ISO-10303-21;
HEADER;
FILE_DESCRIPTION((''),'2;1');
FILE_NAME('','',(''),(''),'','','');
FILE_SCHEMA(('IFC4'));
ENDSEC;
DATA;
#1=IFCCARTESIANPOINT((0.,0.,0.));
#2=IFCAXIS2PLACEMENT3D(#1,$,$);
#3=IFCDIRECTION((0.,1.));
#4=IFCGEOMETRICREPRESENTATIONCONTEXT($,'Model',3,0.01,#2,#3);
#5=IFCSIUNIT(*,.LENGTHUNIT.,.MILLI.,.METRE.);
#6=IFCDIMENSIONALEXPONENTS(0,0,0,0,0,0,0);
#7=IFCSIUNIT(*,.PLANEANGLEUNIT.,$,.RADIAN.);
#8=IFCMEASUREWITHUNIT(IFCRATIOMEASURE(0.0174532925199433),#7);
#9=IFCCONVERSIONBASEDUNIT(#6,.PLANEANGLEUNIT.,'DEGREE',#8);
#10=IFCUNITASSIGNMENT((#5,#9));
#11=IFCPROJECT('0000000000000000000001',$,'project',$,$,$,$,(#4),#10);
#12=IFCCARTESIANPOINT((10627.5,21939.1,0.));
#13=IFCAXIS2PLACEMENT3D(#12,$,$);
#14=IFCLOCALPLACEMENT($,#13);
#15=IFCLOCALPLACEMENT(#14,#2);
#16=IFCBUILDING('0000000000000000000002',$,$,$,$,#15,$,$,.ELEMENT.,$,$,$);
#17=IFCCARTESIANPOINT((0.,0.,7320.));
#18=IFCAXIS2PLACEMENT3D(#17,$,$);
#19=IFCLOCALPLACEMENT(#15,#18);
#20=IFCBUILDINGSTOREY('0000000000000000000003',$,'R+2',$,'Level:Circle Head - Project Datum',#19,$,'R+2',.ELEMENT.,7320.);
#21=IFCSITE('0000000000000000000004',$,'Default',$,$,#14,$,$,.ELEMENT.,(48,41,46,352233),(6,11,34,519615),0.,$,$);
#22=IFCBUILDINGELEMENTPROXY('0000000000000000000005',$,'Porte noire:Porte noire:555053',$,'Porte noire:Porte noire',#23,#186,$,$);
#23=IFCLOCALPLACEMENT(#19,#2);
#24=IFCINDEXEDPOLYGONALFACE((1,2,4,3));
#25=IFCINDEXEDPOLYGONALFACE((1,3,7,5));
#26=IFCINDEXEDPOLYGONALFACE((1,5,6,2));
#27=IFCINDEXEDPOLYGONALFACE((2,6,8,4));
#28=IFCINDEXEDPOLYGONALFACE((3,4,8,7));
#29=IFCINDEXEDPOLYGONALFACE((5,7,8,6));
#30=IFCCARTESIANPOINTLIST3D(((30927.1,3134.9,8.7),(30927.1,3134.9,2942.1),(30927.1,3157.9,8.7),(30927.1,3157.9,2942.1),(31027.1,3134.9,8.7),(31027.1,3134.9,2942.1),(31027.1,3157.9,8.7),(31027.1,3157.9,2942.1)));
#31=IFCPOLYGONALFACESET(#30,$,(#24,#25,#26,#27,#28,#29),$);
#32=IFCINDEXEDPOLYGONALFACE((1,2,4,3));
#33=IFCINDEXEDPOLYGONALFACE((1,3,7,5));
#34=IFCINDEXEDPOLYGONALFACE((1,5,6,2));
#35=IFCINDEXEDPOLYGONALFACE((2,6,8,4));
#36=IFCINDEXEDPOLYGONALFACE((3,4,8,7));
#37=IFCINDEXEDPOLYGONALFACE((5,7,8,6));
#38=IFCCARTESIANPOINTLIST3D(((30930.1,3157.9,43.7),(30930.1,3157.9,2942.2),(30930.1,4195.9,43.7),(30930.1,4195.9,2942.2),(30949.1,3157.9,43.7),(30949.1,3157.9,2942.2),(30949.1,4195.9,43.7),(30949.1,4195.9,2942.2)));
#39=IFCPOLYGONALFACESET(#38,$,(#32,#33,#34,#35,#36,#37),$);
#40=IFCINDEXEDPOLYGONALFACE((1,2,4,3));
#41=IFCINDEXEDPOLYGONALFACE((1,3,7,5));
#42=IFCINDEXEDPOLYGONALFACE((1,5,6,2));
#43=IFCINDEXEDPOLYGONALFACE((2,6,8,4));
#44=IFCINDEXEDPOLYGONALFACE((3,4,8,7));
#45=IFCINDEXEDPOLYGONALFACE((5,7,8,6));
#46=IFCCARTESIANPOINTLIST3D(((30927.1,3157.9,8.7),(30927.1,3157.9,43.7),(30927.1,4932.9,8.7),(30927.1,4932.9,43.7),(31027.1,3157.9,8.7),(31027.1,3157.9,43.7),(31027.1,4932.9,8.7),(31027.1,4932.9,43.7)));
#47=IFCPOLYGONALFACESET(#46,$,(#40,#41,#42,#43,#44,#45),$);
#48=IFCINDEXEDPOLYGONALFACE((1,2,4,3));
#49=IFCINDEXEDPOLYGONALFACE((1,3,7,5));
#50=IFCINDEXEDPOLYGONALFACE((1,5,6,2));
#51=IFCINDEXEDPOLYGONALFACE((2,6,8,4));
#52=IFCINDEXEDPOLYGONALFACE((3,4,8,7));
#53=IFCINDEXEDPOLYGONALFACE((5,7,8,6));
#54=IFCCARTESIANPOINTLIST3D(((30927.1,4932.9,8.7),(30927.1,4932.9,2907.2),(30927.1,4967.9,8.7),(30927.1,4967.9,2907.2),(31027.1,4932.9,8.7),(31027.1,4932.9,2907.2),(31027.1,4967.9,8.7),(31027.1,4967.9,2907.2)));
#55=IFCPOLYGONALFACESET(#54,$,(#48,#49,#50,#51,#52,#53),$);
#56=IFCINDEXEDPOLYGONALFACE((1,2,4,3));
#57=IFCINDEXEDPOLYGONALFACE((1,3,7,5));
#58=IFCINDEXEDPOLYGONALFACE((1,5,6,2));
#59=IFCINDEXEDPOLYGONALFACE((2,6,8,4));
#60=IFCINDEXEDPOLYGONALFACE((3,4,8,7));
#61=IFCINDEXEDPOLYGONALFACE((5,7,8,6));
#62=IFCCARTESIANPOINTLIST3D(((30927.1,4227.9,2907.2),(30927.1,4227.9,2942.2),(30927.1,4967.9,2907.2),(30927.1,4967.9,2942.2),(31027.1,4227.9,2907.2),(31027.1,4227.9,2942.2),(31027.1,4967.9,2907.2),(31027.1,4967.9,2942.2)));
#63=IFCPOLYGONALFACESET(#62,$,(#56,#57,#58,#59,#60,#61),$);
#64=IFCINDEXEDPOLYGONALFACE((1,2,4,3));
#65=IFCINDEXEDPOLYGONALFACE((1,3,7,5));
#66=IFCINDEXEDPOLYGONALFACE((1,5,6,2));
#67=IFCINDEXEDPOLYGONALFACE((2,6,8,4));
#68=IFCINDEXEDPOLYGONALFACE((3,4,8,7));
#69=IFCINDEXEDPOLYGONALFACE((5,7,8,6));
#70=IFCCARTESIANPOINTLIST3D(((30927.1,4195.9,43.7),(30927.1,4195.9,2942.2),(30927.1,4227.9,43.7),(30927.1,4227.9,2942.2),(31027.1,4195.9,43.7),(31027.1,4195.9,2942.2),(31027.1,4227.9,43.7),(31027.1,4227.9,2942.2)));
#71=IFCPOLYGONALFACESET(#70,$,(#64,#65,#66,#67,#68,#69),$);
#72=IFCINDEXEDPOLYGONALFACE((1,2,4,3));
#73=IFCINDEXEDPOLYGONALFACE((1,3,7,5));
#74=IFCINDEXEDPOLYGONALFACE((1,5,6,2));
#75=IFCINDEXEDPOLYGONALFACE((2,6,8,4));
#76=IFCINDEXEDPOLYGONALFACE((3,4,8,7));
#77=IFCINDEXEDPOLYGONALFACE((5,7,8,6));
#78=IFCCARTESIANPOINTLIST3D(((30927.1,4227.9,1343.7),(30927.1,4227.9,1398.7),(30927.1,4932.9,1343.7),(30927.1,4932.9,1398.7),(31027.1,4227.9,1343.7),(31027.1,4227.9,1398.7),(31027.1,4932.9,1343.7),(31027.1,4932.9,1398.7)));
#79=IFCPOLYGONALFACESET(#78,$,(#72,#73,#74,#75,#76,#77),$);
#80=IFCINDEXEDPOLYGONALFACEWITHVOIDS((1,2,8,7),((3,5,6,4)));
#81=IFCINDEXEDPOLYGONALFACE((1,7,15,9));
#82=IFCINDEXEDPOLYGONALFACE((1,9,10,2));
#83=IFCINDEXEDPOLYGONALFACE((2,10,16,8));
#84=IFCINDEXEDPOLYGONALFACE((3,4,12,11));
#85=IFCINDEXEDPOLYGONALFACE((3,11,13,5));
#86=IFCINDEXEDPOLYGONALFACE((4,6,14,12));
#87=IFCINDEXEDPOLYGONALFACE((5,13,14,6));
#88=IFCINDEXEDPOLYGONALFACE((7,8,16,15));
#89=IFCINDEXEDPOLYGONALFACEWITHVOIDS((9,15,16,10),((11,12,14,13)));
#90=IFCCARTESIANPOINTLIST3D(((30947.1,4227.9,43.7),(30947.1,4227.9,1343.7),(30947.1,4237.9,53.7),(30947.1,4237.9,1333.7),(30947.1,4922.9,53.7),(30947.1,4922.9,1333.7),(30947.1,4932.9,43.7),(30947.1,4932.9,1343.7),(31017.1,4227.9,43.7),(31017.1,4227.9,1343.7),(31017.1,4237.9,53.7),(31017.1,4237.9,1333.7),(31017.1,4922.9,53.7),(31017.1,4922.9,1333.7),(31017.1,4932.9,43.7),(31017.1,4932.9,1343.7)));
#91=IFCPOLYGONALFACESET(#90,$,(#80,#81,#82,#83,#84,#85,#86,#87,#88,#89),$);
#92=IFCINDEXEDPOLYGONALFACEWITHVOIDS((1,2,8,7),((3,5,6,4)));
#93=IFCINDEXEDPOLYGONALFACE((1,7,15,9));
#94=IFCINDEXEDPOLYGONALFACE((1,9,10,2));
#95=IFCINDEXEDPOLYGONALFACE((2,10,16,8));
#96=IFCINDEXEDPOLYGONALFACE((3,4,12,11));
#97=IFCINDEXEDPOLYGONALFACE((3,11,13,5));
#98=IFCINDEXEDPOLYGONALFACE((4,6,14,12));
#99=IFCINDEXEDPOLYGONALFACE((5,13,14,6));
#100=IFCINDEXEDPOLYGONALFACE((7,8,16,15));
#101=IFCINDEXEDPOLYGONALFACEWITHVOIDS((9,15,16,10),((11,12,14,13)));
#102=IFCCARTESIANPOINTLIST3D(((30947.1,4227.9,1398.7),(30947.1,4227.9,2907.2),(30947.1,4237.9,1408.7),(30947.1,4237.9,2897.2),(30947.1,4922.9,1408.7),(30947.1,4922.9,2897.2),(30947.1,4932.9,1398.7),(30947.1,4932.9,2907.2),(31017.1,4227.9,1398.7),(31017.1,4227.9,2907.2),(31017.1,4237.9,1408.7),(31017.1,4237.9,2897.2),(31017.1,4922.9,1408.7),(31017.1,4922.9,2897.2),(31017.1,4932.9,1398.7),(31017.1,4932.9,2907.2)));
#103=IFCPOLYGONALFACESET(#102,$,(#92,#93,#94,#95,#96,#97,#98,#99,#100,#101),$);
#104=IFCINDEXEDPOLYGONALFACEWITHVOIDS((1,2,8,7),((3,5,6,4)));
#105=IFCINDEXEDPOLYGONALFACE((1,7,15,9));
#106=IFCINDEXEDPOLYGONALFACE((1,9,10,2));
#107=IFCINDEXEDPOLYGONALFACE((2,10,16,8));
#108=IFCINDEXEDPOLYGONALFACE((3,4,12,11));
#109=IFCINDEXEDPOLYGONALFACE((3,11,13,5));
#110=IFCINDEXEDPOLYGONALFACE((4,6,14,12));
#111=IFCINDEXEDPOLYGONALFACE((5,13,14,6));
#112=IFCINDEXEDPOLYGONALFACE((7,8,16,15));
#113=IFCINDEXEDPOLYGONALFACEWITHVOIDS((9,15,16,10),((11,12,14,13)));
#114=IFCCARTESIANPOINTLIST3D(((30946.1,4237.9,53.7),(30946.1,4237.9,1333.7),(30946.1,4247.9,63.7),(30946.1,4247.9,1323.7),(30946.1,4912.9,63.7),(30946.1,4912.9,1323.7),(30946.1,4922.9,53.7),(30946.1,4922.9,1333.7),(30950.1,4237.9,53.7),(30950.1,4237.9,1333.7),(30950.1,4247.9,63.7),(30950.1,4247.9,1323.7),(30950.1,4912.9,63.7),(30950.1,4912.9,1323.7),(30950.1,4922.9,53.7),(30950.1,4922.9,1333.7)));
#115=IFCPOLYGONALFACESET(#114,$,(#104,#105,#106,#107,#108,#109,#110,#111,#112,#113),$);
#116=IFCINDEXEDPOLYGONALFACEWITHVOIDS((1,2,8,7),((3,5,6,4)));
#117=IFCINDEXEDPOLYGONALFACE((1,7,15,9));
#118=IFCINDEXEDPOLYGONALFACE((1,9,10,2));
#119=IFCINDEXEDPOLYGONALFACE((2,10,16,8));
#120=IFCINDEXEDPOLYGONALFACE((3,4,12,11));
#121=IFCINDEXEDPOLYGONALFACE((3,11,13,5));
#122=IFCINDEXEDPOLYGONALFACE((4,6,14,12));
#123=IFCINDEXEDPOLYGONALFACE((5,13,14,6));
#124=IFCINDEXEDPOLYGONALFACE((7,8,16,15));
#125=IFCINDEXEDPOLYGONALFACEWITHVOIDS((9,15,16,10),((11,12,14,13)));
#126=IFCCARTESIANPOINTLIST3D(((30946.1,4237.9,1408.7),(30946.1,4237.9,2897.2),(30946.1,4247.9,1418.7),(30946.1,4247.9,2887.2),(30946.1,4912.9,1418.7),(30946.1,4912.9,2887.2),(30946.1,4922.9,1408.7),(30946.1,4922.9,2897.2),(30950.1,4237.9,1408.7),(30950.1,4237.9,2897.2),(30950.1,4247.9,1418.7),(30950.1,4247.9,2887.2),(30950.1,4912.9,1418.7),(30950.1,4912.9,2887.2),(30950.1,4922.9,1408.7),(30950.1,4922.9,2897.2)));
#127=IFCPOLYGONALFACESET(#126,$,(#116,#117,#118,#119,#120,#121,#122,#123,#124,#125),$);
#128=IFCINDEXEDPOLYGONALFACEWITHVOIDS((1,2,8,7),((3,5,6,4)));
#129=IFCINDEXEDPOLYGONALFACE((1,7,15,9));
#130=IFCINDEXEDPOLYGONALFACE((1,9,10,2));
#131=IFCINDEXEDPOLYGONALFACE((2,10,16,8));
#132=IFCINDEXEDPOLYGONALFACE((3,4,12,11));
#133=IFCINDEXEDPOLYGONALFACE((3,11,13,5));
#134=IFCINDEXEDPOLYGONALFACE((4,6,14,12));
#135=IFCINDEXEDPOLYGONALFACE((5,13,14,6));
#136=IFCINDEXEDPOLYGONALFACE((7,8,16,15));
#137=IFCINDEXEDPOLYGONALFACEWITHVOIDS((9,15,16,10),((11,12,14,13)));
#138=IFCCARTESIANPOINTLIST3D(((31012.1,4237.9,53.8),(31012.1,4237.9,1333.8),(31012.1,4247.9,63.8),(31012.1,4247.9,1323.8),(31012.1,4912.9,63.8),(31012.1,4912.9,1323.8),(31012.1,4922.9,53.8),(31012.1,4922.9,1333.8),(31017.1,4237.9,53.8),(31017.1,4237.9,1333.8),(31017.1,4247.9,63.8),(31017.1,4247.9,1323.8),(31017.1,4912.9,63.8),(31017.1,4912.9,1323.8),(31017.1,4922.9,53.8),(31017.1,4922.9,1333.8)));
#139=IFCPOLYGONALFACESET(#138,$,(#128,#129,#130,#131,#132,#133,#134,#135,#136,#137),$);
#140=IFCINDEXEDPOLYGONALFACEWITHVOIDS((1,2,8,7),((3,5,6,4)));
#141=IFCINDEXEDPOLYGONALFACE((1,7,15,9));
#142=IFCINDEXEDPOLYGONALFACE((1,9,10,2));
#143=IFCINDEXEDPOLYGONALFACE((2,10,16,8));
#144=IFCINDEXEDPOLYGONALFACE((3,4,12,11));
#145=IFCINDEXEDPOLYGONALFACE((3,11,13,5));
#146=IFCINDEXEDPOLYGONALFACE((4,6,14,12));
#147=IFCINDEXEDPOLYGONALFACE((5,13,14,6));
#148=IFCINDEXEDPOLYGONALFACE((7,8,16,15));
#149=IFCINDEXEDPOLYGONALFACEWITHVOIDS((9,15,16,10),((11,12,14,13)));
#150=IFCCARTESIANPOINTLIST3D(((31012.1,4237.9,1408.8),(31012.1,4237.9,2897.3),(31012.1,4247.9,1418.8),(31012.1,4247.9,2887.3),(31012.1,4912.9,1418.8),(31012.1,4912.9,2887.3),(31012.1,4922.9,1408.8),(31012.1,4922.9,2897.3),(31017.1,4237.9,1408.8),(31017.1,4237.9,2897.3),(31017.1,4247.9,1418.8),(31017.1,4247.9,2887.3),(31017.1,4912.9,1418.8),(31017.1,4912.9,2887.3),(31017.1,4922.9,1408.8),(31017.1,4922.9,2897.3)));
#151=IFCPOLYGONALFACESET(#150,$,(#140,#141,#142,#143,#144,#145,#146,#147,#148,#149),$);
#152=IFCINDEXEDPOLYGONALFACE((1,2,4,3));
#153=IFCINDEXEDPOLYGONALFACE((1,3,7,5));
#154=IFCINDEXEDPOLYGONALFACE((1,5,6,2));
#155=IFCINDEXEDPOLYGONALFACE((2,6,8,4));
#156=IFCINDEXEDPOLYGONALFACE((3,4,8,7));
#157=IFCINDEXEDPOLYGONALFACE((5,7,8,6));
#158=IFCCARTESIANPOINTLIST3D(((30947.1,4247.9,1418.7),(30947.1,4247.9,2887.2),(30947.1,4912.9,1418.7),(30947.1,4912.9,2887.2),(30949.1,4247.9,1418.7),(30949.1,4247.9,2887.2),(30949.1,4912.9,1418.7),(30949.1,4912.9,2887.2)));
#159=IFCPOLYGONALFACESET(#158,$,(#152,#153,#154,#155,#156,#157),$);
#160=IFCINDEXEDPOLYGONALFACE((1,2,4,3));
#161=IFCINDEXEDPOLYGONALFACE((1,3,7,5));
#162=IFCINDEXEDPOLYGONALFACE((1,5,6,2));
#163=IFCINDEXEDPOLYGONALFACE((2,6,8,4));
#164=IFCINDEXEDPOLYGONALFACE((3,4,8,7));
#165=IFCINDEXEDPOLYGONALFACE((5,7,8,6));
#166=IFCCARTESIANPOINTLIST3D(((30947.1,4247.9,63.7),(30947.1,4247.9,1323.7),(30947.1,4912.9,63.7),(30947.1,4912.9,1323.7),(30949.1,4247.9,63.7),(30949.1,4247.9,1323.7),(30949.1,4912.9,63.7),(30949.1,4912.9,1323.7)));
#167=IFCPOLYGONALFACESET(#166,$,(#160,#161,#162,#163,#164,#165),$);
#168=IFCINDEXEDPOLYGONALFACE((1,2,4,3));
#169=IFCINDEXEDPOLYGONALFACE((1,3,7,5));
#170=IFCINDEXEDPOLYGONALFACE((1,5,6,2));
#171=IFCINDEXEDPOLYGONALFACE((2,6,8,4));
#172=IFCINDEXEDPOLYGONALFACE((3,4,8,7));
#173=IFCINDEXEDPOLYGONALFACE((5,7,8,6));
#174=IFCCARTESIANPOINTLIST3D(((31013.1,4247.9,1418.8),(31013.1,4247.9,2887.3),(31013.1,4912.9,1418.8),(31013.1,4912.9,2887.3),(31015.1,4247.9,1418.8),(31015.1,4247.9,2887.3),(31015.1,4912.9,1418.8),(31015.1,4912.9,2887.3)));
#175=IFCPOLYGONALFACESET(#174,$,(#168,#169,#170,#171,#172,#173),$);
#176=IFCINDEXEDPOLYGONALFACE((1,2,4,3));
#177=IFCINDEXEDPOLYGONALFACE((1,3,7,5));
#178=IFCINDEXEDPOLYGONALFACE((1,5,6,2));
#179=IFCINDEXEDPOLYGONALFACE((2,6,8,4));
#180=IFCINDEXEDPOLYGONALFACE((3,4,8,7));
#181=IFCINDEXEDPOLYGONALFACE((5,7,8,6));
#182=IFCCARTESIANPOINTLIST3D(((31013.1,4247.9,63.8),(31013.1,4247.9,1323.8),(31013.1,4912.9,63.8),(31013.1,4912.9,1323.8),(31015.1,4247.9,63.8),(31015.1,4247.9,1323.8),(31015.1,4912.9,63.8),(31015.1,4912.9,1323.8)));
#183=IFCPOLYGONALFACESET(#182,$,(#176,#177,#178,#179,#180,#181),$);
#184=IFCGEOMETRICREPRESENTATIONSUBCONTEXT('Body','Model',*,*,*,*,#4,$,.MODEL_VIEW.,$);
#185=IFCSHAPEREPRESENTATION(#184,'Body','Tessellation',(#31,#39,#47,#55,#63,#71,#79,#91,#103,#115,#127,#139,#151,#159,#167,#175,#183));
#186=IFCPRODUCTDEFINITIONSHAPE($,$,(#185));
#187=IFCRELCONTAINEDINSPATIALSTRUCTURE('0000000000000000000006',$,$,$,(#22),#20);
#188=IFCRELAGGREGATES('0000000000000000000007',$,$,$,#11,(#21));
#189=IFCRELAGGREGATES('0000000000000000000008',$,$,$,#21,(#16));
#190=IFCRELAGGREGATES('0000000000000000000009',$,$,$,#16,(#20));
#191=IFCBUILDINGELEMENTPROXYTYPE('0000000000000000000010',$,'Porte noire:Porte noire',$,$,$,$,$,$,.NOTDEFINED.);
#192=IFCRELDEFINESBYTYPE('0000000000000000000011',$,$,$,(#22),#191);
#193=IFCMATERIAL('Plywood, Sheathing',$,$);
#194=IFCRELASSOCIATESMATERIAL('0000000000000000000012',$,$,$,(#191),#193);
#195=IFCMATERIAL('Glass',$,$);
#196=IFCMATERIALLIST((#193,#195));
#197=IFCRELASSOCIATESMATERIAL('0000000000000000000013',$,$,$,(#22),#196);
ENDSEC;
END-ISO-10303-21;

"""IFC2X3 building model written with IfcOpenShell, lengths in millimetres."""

from ifc_helpers import new_model, entity, si_unit, converted_unit, direction, frame, frame_2d, origin, origin_2d_with_axis, place, context, subcontext, project, spatial, polyline, rectangle, outline, extrude, source, transform, mapped, material, material_list, type_object, type_shapes, element, save


model = new_model("IFC2X3")

# Units and contexts
model_context = context("Model", 3, precision=0.01, world=origin(), true_north=direction((0.0, 1.0)))
body_context = subcontext(model_context, "Body", "Model", "MODEL_VIEW")
ifc_project = project(units=[si_unit("LENGTHUNIT", "METRE", prefix="MILLI"), converted_unit("PLANEANGLEUNIT", "DEGREE", entity("IfcRatioMeasure", 0.0174532925199433), si_unit("PLANEANGLEUNIT", "RADIAN"), dimensions=[0, 0, 0, 0, 0, 0, 0])], contexts=[model_context])

# Site, building, storey
site_placement = place(None, frame((10627.5, 21939.1, 0.0)))
site = spatial("IfcSite", under=ifc_project, at=site_placement, Name="Default", CompositionType="ELEMENT", RefLatitude=(48, 41, 46, 352233), RefLongitude=(6, 11, 34, 519615), RefElevation=0.0)
building_placement = place(site_placement, origin())
building = spatial("IfcBuilding", under=site, at=building_placement, CompositionType="ELEMENT")
storey_placement = place(building_placement, frame((0.0, 0.0, 7320.0)))
storey = spatial("IfcBuildingStorey", under=building, at=storey_placement, Name="R+2", ObjectType="Level:Circle Head - Project Datum", LongName="R+2", CompositionType="ELEMENT", Elevation=7320.0)

# Building element proxy
ifc_material_1 = material(Name="Glass")
ifc_material_2 = material(Name="Plywood, Sheathing")
building_element_proxy_type_1 = type_object("IfcBuildingElementProxyType", Name="Porte noire:Porte noire", PredefinedType="NOTDEFINED", material=ifc_material_2)
shared_shape_1 = source(origin(), body_context, "Body", "SweptSolid", [
    extrude(rectangle(XDim=23.0, YDim=100.0, at=frame_2d((0.0, 0.0), x_axis=(1.0, 0.0))), frame((-950.9, 50.0, 8.7), z_axis=(0.0, 0.0, 1.0), x_axis=(-1.0, 0.0, 0.0)), (0.0, 0.0, 1.0), 2933.3),
    extrude(rectangle(XDim=1038.0, YDim=19.0, at=frame_2d((0.0, 0.0), x_axis=(1.0, 0.0))), frame((-420.4, 87.5, 43.7), z_axis=(0.0, 0.0, 1.0), x_axis=(-1.0, 0.0, 0.0)), (0.0, 0.0, 1.0), 2898.5),
    extrude(rectangle(XDim=1775.0, YDim=100.0, at=origin_2d_with_axis()), frame((-51.9, 50.0, 8.7), z_axis=(0.0, 0.0, 1.0), x_axis=(-1.0, 0.0, 0.0)), (0.0, 0.0, 1.0), 35.0),
    extrude(rectangle(XDim=35.0, YDim=100.0, at=origin_2d_with_axis()), frame((853.1, 50.0, 8.7), z_axis=(0.0, 0.0, 1.0), x_axis=(-1.0, 0.0, 0.0)), (0.0, 0.0, 1.0), 2898.5),
    extrude(rectangle(XDim=740.0, YDim=100.0, at=origin_2d_with_axis()), frame((500.6, 50.0, 2907.2), z_axis=(0.0, 0.0, 1.0), x_axis=(-1.0, 0.0, 0.0)), (0.0, 0.0, 1.0), 35.0),
    extrude(rectangle(XDim=32.0, YDim=100.0, at=origin_2d_with_axis()), frame((114.6, 50.0, 43.7), z_axis=(0.0, 0.0, 1.0), x_axis=(-1.0, 0.0, 0.0)), (0.0, 0.0, 1.0), 2898.5),
    extrude(rectangle(XDim=705.0, YDim=100.0, at=origin_2d_with_axis()), frame((483.1, 50.0, 1343.7), z_axis=(0.0, 0.0, 1.0), x_axis=(-1.0, 0.0, 0.0)), (0.0, 0.0, 1.0), 55.0),
    extrude(outline(polyline([(-352.5, -650.0), (352.5, -650.0), (352.5, 650.0), (-352.5, 650.0), (-352.5, -650.0)]), holes=[polyline([(342.5, 640.0), (342.5, -640.0), (-342.5, -640.0), (-342.5, 640.0), (342.5, 640.0)])]), frame((483.1, 10.0, 693.7), z_axis=(0.0, 1.0, 0.0), x_axis=(1.0, 0.0, 0.0)), (0.0, 0.0, 1.0), 70.0),
    extrude(outline(polyline([(-754.2, -352.5), (754.2, -352.5), (754.2, 352.5), (-754.2, 352.5), (-754.2, -352.5)]), holes=[polyline([(744.2, 342.5), (744.2, -342.5), (-744.2, -342.5), (-744.2, 342.5), (744.2, 342.5)])]), frame((483.1, 10.0, 2153.0), z_axis=(0.0, 1.0, 0.0), x_axis=(0.0, 0.0, 1.0)), (0.0, 0.0, 1.0), 70.0),
    extrude(outline(polyline([(-640.0, -342.5), (640.0, -342.5), (640.0, 342.5), (-640.0, 342.5), (-640.0, -342.5)]), holes=[polyline([(630.0, 332.5), (630.0, -332.5), (-630.0, -332.5), (-630.0, 332.5), (630.0, 332.5)])]), frame((483.1, 77.0, 693.7), z_axis=(0.0, 1.0, 0.0), x_axis=(0.0, 0.0, 1.0)), (0.0, 0.0, 1.0), 4.0),
    extrude(outline(polyline([(-744.2, -342.5), (744.2, -342.5), (744.2, 342.5), (-744.2, 342.5), (-744.2, -342.5)]), holes=[polyline([(734.2, 332.5), (734.2, -332.5), (-734.2, -332.5), (-734.2, 332.5), (734.2, 332.5)])]), frame((483.1, 77.0, 2153.0), z_axis=(0.0, 1.0, 0.0), x_axis=(0.0, 0.0, 1.0)), (0.0, 0.0, 1.0), 4.0),
    extrude(outline(polyline([(-640.0, -342.5), (640.0, -342.5), (640.0, 342.5), (-640.0, 342.5), (-640.0, -342.5)]), holes=[polyline([(630.0, 332.5), (630.0, -332.5), (-630.0, -332.5), (-630.0, 332.5), (630.0, 332.5)])]), frame((483.1, 10.0, 693.8), z_axis=(0.0, 1.0, 0.0), x_axis=(0.0, 0.0, 1.0)), (0.0, 0.0, 1.0), 5.0),
    extrude(outline(polyline([(-744.2, -342.5), (744.2, -342.5), (744.2, 342.5), (-744.2, 342.5), (-744.2, -342.5)]), holes=[polyline([(734.2, 332.5), (734.2, -332.5), (-734.2, -332.5), (-734.2, 332.5), (734.2, 332.5)])]), frame((483.1, 10.0, 2153.0), z_axis=(0.0, 1.0, 0.0), x_axis=(0.0, 0.0, 1.0)), (0.0, 0.0, 1.0), 5.0),
    extrude(rectangle(XDim=665.0, YDim=2.0, at=frame_2d((0.0, 0.0), x_axis=(1.0, 0.0))), frame((483.1, 79.0, 1418.7), z_axis=(0.0, 0.0, 1.0), x_axis=(-1.0, 0.0, 0.0)), (0.0, 0.0, 1.0), 1468.5),
    extrude(rectangle(XDim=665.0, YDim=2.0, at=frame_2d((0.0, 0.0), x_axis=(1.0, 0.0))), frame((483.1, 79.0, 63.7), z_axis=(0.0, 0.0, 1.0), x_axis=(-1.0, 0.0, 0.0)), (0.0, 0.0, 1.0), 1260.0),
    extrude(rectangle(XDim=665.0, YDim=2.0, at=frame_2d((0.0, 0.0), x_axis=(1.0, 0.0))), frame((483.1, 13.0, 1418.8), z_axis=(0.0, 0.0, 1.0), x_axis=(-1.0, 0.0, 0.0)), (0.0, 0.0, 1.0), 1468.5),
    extrude(rectangle(XDim=665.0, YDim=2.0, at=frame_2d((0.0, 0.0), x_axis=(1.0, 0.0))), frame((483.1, 13.0, 63.8), z_axis=(0.0, 0.0, 1.0), x_axis=(-1.0, 0.0, 0.0)), (0.0, 0.0, 1.0), 1260.0),
])
type_shapes(building_element_proxy_type_1, [shared_shape_1])
ifc_material_list_1 = material_list([ifc_material_2, ifc_material_1])
proxy_1_placement = place(storey_placement, frame((31027.1, 4097.3, 0.0), z_axis=(0.0, 0.0, 1.0), x_axis=(0.0, 1.0, 0.0)))
element("IfcBuildingElementProxy", 1, at=proxy_1_placement, inside=storey, type_object=building_element_proxy_type_1, material=ifc_material_list_1, Name="Porte noire:Porte noire:555053", ObjectType="Porte noire:Porte noire", context=body_context, shape_type="MappedRepresentation", body=[
    mapped(shared_shape_1, transform((0.0, 0.0, 0.0), scale=1.0)),
])

save(model, "model.ifc")
